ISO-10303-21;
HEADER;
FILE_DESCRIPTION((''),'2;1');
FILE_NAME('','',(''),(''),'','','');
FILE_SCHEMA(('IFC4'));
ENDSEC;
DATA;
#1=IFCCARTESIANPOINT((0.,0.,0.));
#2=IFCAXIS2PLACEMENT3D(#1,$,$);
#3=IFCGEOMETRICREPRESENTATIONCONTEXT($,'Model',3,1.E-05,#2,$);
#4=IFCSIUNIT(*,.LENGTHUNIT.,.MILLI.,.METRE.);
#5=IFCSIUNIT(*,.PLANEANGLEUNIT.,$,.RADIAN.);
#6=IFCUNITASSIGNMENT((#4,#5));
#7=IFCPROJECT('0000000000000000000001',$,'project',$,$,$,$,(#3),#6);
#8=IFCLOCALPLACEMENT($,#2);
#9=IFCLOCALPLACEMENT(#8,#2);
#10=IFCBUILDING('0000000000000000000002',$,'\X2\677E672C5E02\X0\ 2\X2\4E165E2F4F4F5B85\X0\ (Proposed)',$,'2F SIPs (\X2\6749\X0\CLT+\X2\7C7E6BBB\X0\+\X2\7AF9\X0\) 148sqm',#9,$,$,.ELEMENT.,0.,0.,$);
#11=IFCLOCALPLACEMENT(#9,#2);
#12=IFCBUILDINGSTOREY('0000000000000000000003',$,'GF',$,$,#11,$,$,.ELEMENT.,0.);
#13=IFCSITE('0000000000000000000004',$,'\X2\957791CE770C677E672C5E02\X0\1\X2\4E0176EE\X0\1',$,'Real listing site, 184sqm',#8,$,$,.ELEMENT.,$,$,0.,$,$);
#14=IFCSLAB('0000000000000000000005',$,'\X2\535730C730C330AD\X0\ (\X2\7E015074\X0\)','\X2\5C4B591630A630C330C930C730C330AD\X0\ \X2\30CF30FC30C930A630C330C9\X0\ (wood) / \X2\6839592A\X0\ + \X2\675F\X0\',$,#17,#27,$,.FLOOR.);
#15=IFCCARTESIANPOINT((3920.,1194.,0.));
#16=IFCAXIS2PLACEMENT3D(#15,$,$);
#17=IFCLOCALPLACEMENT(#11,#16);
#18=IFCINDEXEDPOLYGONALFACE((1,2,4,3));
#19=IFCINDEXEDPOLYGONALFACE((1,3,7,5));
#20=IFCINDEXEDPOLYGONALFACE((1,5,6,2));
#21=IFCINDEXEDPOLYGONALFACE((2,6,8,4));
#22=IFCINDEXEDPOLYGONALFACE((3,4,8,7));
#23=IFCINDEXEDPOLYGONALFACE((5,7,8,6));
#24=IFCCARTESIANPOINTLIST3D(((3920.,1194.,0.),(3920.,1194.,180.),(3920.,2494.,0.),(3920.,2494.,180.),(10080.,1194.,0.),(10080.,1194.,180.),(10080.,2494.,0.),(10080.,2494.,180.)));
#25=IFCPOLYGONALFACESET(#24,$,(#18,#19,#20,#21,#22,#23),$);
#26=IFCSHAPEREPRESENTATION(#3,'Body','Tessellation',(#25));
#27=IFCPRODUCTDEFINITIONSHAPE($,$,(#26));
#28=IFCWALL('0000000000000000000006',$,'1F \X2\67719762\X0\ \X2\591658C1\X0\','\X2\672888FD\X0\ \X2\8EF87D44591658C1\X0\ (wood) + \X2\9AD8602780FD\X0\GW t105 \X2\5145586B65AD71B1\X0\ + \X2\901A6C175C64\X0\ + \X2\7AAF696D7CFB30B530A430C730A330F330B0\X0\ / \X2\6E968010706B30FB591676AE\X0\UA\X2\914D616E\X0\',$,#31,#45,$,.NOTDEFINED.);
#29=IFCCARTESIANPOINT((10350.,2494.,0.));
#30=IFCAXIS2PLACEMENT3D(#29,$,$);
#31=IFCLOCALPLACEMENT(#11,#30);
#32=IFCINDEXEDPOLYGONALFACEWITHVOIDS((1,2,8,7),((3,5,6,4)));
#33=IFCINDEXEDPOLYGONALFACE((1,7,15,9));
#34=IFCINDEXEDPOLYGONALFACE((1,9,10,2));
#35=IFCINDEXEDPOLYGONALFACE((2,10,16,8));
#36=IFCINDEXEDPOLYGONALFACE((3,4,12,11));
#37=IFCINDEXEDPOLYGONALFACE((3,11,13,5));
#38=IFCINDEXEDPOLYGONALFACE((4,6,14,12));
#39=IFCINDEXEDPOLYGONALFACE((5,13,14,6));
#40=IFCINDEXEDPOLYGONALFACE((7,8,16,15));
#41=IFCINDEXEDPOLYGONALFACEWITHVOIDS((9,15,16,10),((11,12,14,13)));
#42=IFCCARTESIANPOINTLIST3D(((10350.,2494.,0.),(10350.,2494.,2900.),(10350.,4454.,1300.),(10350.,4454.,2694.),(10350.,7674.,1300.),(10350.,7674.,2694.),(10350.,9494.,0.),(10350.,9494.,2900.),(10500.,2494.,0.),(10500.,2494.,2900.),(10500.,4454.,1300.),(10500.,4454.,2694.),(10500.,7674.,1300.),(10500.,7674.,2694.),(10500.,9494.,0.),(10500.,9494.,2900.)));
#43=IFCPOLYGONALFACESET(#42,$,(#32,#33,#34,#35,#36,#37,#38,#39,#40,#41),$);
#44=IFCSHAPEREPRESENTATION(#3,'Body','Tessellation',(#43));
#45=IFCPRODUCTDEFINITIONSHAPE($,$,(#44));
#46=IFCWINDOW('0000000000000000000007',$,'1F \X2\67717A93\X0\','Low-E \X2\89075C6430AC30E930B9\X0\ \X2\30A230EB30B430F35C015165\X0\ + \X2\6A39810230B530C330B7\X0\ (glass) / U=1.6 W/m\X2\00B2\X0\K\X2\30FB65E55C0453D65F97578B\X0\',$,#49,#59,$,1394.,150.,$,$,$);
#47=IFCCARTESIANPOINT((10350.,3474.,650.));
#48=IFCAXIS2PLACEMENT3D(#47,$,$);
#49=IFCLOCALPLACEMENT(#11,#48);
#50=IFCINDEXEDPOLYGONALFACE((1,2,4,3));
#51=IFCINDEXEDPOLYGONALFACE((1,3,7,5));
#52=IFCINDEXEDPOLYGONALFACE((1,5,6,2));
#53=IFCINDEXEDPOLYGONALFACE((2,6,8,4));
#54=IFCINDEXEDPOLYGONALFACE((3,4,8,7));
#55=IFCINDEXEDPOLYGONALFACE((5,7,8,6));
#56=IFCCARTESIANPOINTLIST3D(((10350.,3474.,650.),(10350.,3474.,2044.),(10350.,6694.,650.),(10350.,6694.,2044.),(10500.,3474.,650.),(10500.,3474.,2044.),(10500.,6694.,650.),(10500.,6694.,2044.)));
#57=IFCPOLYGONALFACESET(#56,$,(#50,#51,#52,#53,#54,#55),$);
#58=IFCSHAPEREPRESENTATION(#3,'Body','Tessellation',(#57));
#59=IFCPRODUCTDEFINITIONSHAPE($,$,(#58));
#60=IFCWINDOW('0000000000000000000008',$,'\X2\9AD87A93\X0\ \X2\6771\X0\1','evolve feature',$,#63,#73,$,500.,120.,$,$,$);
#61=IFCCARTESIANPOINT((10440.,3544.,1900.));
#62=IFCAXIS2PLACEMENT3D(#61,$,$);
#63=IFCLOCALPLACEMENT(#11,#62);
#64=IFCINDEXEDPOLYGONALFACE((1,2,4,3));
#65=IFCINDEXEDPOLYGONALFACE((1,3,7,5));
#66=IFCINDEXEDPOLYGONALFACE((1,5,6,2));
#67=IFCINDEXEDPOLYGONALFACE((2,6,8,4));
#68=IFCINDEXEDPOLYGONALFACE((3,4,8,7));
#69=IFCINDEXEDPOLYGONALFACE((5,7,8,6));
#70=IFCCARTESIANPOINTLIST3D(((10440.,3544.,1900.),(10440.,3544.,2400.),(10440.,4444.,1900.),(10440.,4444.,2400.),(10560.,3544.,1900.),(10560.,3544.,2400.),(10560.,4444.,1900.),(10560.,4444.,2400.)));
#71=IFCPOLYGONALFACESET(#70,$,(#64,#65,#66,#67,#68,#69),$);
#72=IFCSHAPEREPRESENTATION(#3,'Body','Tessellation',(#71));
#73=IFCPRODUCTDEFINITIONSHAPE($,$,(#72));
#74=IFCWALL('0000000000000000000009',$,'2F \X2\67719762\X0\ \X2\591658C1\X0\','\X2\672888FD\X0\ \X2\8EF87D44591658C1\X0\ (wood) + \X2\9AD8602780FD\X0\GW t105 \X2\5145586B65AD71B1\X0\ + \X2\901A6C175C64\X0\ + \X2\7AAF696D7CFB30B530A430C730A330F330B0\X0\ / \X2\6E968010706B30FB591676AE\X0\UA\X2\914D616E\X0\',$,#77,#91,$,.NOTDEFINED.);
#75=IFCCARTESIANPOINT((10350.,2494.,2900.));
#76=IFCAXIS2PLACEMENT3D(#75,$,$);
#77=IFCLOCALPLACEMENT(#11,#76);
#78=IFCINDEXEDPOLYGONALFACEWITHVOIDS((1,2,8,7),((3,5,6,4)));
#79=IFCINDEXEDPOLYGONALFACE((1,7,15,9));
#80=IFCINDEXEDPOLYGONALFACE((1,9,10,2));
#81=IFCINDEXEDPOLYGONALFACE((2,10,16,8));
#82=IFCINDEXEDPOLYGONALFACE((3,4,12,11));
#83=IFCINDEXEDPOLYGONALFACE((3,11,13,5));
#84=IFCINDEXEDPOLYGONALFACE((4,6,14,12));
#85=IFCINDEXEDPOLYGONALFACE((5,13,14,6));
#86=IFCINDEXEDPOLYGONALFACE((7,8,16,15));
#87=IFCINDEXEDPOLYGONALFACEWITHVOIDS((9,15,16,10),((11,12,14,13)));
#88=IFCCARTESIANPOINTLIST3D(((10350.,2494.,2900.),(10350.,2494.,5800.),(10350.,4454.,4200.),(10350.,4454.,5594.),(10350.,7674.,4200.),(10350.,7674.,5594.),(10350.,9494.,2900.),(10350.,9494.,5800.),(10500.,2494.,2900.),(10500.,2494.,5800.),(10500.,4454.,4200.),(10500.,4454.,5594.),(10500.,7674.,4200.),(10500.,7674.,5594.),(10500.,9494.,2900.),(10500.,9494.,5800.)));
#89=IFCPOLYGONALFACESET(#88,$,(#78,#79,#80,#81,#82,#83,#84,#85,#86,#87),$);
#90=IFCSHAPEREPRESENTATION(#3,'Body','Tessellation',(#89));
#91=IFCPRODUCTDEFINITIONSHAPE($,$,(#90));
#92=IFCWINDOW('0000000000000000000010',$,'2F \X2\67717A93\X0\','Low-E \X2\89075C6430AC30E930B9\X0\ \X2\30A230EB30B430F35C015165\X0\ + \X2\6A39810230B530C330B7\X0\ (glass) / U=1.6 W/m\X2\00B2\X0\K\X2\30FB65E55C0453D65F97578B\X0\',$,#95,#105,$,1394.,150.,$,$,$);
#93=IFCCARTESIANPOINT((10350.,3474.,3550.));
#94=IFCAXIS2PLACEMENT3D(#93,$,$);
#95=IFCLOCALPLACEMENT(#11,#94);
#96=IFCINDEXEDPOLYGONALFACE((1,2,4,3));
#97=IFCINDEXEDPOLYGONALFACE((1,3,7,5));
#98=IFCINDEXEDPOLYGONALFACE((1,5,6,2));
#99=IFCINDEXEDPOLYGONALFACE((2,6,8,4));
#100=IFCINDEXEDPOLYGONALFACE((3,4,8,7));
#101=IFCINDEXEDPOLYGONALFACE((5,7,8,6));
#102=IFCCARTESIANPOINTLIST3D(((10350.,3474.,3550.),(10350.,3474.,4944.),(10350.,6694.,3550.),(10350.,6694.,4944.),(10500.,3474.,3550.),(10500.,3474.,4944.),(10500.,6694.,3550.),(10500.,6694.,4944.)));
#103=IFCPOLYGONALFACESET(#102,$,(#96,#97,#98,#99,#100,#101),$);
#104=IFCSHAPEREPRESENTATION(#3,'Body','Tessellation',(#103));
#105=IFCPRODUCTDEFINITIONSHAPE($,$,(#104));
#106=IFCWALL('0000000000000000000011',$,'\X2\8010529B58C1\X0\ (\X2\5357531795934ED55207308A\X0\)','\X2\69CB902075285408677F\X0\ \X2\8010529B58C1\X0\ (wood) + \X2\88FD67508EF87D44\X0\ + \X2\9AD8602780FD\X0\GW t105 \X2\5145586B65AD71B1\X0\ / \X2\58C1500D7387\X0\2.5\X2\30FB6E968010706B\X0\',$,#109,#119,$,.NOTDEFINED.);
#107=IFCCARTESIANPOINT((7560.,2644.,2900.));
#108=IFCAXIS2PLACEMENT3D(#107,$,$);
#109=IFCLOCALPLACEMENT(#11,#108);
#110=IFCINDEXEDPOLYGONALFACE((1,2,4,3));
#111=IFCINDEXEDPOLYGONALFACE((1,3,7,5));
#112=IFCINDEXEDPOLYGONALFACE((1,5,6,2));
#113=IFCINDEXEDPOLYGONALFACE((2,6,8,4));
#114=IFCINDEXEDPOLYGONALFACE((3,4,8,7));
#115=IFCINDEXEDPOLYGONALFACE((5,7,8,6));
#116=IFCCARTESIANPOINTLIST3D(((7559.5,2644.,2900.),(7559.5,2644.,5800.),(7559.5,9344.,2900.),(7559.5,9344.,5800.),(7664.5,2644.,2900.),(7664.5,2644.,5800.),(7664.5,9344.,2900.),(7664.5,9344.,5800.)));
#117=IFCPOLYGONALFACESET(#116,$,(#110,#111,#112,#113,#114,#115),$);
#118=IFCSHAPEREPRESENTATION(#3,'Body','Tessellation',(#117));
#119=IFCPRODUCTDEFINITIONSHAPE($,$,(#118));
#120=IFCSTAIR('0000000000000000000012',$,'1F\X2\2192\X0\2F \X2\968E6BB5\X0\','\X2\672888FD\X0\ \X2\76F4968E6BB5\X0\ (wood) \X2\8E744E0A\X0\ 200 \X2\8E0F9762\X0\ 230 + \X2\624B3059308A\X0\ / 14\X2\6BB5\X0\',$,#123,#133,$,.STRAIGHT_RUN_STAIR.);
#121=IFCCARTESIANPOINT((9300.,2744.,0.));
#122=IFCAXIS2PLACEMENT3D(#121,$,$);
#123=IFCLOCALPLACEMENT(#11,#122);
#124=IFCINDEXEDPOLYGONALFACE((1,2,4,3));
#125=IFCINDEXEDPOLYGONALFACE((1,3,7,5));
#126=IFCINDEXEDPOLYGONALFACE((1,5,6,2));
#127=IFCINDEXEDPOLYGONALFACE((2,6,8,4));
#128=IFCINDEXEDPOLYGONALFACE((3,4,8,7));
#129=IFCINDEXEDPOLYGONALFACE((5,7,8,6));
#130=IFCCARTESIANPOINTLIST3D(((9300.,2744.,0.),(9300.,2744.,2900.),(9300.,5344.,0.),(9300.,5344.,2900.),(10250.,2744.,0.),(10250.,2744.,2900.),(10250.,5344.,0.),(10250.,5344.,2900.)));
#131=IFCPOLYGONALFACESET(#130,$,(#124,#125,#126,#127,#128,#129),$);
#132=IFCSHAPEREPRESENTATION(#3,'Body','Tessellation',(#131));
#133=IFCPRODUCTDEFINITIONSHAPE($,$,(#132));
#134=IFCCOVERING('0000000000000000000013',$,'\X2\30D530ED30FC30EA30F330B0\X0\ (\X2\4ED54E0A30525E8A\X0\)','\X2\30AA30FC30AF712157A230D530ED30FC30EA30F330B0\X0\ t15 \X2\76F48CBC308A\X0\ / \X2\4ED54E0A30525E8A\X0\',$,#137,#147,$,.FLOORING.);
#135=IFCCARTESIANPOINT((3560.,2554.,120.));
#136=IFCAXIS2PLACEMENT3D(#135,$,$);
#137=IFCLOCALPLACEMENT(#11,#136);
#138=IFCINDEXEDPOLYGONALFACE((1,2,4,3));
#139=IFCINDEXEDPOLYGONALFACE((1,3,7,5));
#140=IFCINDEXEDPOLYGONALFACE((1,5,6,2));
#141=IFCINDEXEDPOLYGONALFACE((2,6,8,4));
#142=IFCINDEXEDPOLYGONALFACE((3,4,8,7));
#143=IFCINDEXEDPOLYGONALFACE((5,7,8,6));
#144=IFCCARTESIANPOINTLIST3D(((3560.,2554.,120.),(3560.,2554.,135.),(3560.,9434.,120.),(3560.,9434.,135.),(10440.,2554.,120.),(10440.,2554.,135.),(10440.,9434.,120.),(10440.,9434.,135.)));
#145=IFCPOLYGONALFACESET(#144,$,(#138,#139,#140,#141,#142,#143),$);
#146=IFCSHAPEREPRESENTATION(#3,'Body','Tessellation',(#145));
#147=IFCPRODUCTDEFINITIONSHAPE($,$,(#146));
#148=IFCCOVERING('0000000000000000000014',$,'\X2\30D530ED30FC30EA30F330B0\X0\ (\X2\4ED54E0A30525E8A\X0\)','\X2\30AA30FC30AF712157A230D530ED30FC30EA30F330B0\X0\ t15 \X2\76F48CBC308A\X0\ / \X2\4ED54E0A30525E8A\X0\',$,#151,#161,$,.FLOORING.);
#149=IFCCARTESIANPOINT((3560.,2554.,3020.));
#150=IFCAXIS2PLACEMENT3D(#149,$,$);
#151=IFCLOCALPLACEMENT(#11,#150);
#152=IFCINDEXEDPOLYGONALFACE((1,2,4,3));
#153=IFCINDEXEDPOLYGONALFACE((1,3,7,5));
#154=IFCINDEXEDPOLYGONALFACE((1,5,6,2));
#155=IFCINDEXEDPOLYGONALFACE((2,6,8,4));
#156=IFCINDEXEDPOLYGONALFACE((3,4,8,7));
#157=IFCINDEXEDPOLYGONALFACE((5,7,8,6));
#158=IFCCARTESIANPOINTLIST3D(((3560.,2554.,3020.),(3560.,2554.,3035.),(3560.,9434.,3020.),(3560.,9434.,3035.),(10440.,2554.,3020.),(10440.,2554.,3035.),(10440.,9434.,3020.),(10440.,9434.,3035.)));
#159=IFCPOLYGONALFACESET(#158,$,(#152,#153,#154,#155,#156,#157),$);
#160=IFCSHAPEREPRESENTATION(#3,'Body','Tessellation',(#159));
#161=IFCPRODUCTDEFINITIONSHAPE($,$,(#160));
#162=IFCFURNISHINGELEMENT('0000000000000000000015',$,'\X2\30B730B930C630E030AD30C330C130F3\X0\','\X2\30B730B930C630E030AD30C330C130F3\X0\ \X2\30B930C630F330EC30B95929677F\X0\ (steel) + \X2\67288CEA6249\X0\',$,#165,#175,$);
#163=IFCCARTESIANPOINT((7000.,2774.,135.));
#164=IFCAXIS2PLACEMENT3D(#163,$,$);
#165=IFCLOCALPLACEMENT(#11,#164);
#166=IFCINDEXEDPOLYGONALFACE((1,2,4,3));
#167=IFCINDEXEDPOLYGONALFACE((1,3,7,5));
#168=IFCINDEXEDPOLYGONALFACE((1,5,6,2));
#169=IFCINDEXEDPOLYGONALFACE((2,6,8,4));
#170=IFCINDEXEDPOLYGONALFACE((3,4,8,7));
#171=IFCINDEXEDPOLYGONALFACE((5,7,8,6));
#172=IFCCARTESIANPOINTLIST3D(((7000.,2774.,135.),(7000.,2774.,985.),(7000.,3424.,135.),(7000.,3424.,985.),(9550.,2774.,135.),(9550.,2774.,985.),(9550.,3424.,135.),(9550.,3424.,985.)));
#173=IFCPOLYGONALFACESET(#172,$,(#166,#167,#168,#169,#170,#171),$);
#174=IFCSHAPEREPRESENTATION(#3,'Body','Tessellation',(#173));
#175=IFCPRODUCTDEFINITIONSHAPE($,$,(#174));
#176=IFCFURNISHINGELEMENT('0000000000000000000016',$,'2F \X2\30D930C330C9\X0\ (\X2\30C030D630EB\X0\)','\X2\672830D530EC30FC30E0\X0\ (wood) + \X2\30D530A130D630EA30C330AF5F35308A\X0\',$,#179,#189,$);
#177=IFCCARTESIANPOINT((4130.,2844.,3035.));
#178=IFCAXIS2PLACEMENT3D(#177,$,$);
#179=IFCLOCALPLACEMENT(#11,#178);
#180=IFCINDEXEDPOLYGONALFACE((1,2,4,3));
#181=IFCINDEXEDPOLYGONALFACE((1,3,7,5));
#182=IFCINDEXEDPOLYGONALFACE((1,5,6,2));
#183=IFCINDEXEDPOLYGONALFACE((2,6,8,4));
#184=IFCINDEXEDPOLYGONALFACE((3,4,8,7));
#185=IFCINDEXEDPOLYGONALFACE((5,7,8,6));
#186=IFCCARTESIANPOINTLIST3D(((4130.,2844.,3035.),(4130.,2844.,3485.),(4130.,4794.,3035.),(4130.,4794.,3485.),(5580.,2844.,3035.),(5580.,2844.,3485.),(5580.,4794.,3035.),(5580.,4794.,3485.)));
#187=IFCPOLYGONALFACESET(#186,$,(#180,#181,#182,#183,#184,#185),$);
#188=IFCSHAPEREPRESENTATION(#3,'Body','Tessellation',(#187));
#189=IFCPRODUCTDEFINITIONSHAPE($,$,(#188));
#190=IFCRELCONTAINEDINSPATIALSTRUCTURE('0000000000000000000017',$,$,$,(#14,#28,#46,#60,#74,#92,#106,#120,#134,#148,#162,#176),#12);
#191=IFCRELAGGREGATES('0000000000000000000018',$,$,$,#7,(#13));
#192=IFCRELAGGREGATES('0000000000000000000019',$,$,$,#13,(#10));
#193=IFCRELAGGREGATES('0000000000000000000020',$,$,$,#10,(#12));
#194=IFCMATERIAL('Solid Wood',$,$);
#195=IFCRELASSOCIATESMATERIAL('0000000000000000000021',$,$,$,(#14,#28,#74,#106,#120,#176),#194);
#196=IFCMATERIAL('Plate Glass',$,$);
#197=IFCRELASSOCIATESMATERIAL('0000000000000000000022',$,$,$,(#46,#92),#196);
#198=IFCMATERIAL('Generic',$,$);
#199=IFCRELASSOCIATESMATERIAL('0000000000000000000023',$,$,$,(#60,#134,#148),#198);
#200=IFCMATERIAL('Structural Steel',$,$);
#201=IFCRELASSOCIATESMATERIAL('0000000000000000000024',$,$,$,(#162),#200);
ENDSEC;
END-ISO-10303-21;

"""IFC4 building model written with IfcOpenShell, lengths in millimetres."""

from ifc_helpers import new_model, si_unit, frame, frame_2d, origin, place, context, project, spatial, rectangle, extrude, material, element, fill, save


model = new_model("IFC4")

# Units and contexts
model_context = context("Model", 3, precision=1e-05, world=origin())
ifc_project = project(units=[si_unit("LENGTHUNIT", "METRE", prefix="MILLI"), si_unit("PLANEANGLEUNIT", "RADIAN")], contexts=[model_context])

# Site, building, storey
site_placement = place(None, origin())
site = spatial("IfcSite", under=ifc_project, at=site_placement, Name="長野県松本市1丁目1", ObjectType="Real listing site, 184sqm", CompositionType="ELEMENT", RefElevation=0.0)
building_placement = place(site_placement, origin())
building = spatial("IfcBuilding", under=site, at=building_placement, Name="松本市 2世帯住宅 (Proposed)", ObjectType="2F SIPs (杉CLT+籾殻+竹) 148sqm", CompositionType="ELEMENT", ElevationOfRefHeight=0.0, ElevationOfTerrain=0.0)
storey_placement = place(building_placement, origin())
storey = spatial("IfcBuildingStorey", under=building, at=storey_placement, Name="GF", CompositionType="ELEMENT", Elevation=0.0)

# Slab
ifc_material_1 = material(Name="Solid Wood")
slab_placement = place(storey_placement, frame((3920.0, 1194.0, 0.0)))
element("IfcSlab", 1, at=slab_placement, inside=storey, material=ifc_material_1, Name="南デッキ (縁側)", Description="屋外ウッドデッキ ハードウッド (wood) / 根太 + 束", PredefinedType="FLOOR", context=model_context, shape_type="SweptSolid", body=[
    extrude(rectangle(XDim=6160.0, YDim=1300.0, at=frame_2d((3080.0, 650.0))), frame((3920.0, 1194.0, 0.0)), (0.0, 0.0, 1.0), 180.0),
])

# Wall, openings, windows
wall_1_placement = place(storey_placement, frame((10350.0, 2494.0, 0.0)))
wall_1 = element("IfcWall", 2, at=wall_1_placement, inside=storey, material=ifc_material_1, Name="1F 東面 外壁", Description="木製 軸組外壁 (wood) + 高性能GW t105 充填断熱 + 通気層 + 窯業系サイディング / 準耐火・外皮UA配慮", PredefinedType="NOTDEFINED", context=model_context, shape_type="SweptSolid", body=[
    extrude(rectangle(XDim=150.0, YDim=7000.0, at=frame_2d((75.0, 3500.0))), frame((10350.0, 2494.0, 0.0)), (0.0, 0.0, 1.0), 2900.0),
])
opening_1_placement = place(storey_placement, frame((10350.0, 3474.0, 650.0)))
opening_1 = element("IfcOpeningElement", 3, at=opening_1_placement, cuts=wall_1, PredefinedType="NOTDEFINED", context=model_context, shape_type="SweptSolid", body=[
    extrude(rectangle(XDim=150.0, YDim=3220.0, at=frame_2d((75.0, 1610.0))), frame((10350.0, 3474.0, 650.0)), (0.0, 0.0, 1.0), 1394.0),
])
opening_2_placement = place(storey_placement, frame((10440.0, 3544.0, 1900.0)))
opening_2 = element("IfcOpeningElement", 4, at=opening_2_placement, cuts=wall_1, PredefinedType="NOTDEFINED", context=model_context, shape_type="SweptSolid", body=[
    extrude(rectangle(XDim=120.0, YDim=900.0, at=frame_2d((60.0, 450.0))), frame((10440.0, 3544.0, 1900.0)), (0.0, 0.0, 1.0), 500.0),
])
ifc_material_2 = material(Name="Plate Glass")
window_1_placement = place(storey_placement, frame((10350.0, 3474.0, 650.0)))
window_1 = element("IfcWindow", 5, at=window_1_placement, inside=storey, material=ifc_material_2, Name="1F 東窓", Description="Low-E 複層ガラス アルゴン封入 + 樹脂サッシ (glass) / U=1.6 W/m²K・日射取得型", OverallHeight=1394.0, OverallWidth=150.0, context=model_context, shape_type="SweptSolid", body=[
    extrude(rectangle(XDim=150.0, YDim=3220.0, at=frame_2d((75.0, 1610.0))), frame((10350.0, 3474.0, 650.0)), (0.0, 0.0, 1.0), 1394.0),
])
fill(opening_1, window_1)
ifc_material_3 = material(Name="Generic")
window_2_placement = place(storey_placement, frame((10440.0, 3544.0, 1900.0)))
window_2 = element("IfcWindow", 6, at=window_2_placement, inside=storey, material=ifc_material_3, Name="高窓 東1", Description="evolve feature", OverallHeight=500.0, OverallWidth=120.0, context=model_context, shape_type="SweptSolid", body=[
    extrude(rectangle(XDim=120.0, YDim=900.0, at=frame_2d((60.0, 450.0))), frame((10440.0, 3544.0, 1900.0)), (0.0, 0.0, 1.0), 500.0),
])
fill(opening_2, window_2)

# Wall, opening, window
wall_2_placement = place(storey_placement, frame((10350.0, 2494.0, 2900.0)))
wall_2 = element("IfcWall", 7, at=wall_2_placement, inside=storey, material=ifc_material_1, Name="2F 東面 外壁", Description="木製 軸組外壁 (wood) + 高性能GW t105 充填断熱 + 通気層 + 窯業系サイディング / 準耐火・外皮UA配慮", PredefinedType="NOTDEFINED", context=model_context, shape_type="SweptSolid", body=[
    extrude(rectangle(XDim=150.0, YDim=7000.0, at=frame_2d((75.0, 3500.0))), frame((10350.0, 2494.0, 2900.0)), (0.0, 0.0, 1.0), 2900.0),
])
opening_3_placement = place(storey_placement, frame((10350.0, 3474.0, 3550.0)))
opening_3 = element("IfcOpeningElement", 8, at=opening_3_placement, cuts=wall_2, PredefinedType="NOTDEFINED", context=model_context, shape_type="SweptSolid", body=[
    extrude(rectangle(XDim=150.0, YDim=3220.0, at=frame_2d((75.0, 1610.0))), frame((10350.0, 3474.0, 3550.0)), (0.0, 0.0, 1.0), 1394.0),
])
window_3_placement = place(storey_placement, frame((10350.0, 3474.0, 3550.0)))
window_3 = element("IfcWindow", 9, at=window_3_placement, inside=storey, material=ifc_material_2, Name="2F 東窓", Description="Low-E 複層ガラス アルゴン封入 + 樹脂サッシ (glass) / U=1.6 W/m²K・日射取得型", OverallHeight=1394.0, OverallWidth=150.0, context=model_context, shape_type="SweptSolid", body=[
    extrude(rectangle(XDim=150.0, YDim=3220.0, at=frame_2d((75.0, 1610.0))), frame((10350.0, 3474.0, 3550.0)), (0.0, 0.0, 1.0), 1394.0),
])
fill(opening_3, window_3)

# Wall
wall_3_placement = place(storey_placement, frame((7560.0, 2644.0, 2900.0)))
element("IfcWall", 10, at=wall_3_placement, inside=storey, material=ifc_material_1, Name="耐力壁 (南北間仕切り)", Description="構造用合板 耐力壁 (wood) + 製材軸組 + 高性能GW t105 充填断熱 / 壁倍率2.5・準耐火", PredefinedType="NOTDEFINED", context=model_context, shape_type="SweptSolid", body=[
    extrude(rectangle(XDim=105.0, YDim=6700.0, at=frame_2d((52.0, 3350.0))), frame((7560.0, 2644.0, 2900.0)), (0.0, 0.0, 1.0), 2900.0),
])

# Stair
stair_placement = place(storey_placement, frame((9300.0, 2744.0, 0.0)))
element("IfcStair", 11, at=stair_placement, inside=storey, material=ifc_material_1, Name="1F→2F 階段", Description="木製 直階段 (wood) 蹴上 200 踏面 230 + 手すり / 14段", PredefinedType="STRAIGHT_RUN_STAIR", context=model_context, shape_type="SweptSolid", body=[
    extrude(rectangle(XDim=950.0, YDim=2600.0, at=frame_2d((475.0, 1300.0))), frame((9300.0, 2744.0, 0.0)), (0.0, 0.0, 1.0), 2900.0),
])

# Coverings
covering_1_placement = place(storey_placement, frame((3560.0, 2554.0, 120.0)))
element("IfcCovering", 12, at=covering_1_placement, inside=storey, material=ifc_material_3, Name="フローリング (仕上げ床)", Description="オーク無垢フローリング t15 直貼り / 仕上げ床", PredefinedType="FLOORING", context=model_context, shape_type="SweptSolid", body=[
    extrude(rectangle(XDim=6880.0, YDim=6880.0, at=frame_2d((3440.0, 3440.0))), frame((3560.0, 2554.0, 120.0)), (0.0, 0.0, 1.0), 15.0),
])
covering_2_placement = place(storey_placement, frame((3560.0, 2554.0, 3020.0)))
element("IfcCovering", 13, at=covering_2_placement, inside=storey, material=ifc_material_3, Name="フローリング (仕上げ床)", Description="オーク無垢フローリング t15 直貼り / 仕上げ床", PredefinedType="FLOORING", context=model_context, shape_type="SweptSolid", body=[
    extrude(rectangle(XDim=6880.0, YDim=6880.0, at=frame_2d((3440.0, 3440.0))), frame((3560.0, 2554.0, 3020.0)), (0.0, 0.0, 1.0), 15.0),
])

# Furnishing elements
ifc_material_4 = material(Name="Structural Steel")
furnishing_1_placement = place(storey_placement, frame((7000.0, 2774.0, 135.0)))
element("IfcFurnishingElement", 14, at=furnishing_1_placement, inside=storey, material=ifc_material_4, Name="システムキッチン", Description="システムキッチン ステンレス天板 (steel) + 木質扉", context=model_context, shape_type="SweptSolid", body=[
    extrude(rectangle(XDim=2550.0, YDim=650.0, at=frame_2d((1275.0, 325.0))), frame((7000.0, 2774.0, 135.0)), (0.0, 0.0, 1.0), 850.0),
])
furnishing_2_placement = place(storey_placement, frame((4130.0, 2844.0, 3035.0)))
element("IfcFurnishingElement", 15, at=furnishing_2_placement, inside=storey, material=ifc_material_1, Name="2F ベッド (ダブル)", Description="木フレーム (wood) + ファブリック張り", context=model_context, shape_type="SweptSolid", body=[
    extrude(rectangle(XDim=1450.0, YDim=1950.0, at=frame_2d((725.0, 975.0))), frame((4130.0, 2844.0, 3035.0)), (0.0, 0.0, 1.0), 450.0),
])

save(model, "model.ifc")
